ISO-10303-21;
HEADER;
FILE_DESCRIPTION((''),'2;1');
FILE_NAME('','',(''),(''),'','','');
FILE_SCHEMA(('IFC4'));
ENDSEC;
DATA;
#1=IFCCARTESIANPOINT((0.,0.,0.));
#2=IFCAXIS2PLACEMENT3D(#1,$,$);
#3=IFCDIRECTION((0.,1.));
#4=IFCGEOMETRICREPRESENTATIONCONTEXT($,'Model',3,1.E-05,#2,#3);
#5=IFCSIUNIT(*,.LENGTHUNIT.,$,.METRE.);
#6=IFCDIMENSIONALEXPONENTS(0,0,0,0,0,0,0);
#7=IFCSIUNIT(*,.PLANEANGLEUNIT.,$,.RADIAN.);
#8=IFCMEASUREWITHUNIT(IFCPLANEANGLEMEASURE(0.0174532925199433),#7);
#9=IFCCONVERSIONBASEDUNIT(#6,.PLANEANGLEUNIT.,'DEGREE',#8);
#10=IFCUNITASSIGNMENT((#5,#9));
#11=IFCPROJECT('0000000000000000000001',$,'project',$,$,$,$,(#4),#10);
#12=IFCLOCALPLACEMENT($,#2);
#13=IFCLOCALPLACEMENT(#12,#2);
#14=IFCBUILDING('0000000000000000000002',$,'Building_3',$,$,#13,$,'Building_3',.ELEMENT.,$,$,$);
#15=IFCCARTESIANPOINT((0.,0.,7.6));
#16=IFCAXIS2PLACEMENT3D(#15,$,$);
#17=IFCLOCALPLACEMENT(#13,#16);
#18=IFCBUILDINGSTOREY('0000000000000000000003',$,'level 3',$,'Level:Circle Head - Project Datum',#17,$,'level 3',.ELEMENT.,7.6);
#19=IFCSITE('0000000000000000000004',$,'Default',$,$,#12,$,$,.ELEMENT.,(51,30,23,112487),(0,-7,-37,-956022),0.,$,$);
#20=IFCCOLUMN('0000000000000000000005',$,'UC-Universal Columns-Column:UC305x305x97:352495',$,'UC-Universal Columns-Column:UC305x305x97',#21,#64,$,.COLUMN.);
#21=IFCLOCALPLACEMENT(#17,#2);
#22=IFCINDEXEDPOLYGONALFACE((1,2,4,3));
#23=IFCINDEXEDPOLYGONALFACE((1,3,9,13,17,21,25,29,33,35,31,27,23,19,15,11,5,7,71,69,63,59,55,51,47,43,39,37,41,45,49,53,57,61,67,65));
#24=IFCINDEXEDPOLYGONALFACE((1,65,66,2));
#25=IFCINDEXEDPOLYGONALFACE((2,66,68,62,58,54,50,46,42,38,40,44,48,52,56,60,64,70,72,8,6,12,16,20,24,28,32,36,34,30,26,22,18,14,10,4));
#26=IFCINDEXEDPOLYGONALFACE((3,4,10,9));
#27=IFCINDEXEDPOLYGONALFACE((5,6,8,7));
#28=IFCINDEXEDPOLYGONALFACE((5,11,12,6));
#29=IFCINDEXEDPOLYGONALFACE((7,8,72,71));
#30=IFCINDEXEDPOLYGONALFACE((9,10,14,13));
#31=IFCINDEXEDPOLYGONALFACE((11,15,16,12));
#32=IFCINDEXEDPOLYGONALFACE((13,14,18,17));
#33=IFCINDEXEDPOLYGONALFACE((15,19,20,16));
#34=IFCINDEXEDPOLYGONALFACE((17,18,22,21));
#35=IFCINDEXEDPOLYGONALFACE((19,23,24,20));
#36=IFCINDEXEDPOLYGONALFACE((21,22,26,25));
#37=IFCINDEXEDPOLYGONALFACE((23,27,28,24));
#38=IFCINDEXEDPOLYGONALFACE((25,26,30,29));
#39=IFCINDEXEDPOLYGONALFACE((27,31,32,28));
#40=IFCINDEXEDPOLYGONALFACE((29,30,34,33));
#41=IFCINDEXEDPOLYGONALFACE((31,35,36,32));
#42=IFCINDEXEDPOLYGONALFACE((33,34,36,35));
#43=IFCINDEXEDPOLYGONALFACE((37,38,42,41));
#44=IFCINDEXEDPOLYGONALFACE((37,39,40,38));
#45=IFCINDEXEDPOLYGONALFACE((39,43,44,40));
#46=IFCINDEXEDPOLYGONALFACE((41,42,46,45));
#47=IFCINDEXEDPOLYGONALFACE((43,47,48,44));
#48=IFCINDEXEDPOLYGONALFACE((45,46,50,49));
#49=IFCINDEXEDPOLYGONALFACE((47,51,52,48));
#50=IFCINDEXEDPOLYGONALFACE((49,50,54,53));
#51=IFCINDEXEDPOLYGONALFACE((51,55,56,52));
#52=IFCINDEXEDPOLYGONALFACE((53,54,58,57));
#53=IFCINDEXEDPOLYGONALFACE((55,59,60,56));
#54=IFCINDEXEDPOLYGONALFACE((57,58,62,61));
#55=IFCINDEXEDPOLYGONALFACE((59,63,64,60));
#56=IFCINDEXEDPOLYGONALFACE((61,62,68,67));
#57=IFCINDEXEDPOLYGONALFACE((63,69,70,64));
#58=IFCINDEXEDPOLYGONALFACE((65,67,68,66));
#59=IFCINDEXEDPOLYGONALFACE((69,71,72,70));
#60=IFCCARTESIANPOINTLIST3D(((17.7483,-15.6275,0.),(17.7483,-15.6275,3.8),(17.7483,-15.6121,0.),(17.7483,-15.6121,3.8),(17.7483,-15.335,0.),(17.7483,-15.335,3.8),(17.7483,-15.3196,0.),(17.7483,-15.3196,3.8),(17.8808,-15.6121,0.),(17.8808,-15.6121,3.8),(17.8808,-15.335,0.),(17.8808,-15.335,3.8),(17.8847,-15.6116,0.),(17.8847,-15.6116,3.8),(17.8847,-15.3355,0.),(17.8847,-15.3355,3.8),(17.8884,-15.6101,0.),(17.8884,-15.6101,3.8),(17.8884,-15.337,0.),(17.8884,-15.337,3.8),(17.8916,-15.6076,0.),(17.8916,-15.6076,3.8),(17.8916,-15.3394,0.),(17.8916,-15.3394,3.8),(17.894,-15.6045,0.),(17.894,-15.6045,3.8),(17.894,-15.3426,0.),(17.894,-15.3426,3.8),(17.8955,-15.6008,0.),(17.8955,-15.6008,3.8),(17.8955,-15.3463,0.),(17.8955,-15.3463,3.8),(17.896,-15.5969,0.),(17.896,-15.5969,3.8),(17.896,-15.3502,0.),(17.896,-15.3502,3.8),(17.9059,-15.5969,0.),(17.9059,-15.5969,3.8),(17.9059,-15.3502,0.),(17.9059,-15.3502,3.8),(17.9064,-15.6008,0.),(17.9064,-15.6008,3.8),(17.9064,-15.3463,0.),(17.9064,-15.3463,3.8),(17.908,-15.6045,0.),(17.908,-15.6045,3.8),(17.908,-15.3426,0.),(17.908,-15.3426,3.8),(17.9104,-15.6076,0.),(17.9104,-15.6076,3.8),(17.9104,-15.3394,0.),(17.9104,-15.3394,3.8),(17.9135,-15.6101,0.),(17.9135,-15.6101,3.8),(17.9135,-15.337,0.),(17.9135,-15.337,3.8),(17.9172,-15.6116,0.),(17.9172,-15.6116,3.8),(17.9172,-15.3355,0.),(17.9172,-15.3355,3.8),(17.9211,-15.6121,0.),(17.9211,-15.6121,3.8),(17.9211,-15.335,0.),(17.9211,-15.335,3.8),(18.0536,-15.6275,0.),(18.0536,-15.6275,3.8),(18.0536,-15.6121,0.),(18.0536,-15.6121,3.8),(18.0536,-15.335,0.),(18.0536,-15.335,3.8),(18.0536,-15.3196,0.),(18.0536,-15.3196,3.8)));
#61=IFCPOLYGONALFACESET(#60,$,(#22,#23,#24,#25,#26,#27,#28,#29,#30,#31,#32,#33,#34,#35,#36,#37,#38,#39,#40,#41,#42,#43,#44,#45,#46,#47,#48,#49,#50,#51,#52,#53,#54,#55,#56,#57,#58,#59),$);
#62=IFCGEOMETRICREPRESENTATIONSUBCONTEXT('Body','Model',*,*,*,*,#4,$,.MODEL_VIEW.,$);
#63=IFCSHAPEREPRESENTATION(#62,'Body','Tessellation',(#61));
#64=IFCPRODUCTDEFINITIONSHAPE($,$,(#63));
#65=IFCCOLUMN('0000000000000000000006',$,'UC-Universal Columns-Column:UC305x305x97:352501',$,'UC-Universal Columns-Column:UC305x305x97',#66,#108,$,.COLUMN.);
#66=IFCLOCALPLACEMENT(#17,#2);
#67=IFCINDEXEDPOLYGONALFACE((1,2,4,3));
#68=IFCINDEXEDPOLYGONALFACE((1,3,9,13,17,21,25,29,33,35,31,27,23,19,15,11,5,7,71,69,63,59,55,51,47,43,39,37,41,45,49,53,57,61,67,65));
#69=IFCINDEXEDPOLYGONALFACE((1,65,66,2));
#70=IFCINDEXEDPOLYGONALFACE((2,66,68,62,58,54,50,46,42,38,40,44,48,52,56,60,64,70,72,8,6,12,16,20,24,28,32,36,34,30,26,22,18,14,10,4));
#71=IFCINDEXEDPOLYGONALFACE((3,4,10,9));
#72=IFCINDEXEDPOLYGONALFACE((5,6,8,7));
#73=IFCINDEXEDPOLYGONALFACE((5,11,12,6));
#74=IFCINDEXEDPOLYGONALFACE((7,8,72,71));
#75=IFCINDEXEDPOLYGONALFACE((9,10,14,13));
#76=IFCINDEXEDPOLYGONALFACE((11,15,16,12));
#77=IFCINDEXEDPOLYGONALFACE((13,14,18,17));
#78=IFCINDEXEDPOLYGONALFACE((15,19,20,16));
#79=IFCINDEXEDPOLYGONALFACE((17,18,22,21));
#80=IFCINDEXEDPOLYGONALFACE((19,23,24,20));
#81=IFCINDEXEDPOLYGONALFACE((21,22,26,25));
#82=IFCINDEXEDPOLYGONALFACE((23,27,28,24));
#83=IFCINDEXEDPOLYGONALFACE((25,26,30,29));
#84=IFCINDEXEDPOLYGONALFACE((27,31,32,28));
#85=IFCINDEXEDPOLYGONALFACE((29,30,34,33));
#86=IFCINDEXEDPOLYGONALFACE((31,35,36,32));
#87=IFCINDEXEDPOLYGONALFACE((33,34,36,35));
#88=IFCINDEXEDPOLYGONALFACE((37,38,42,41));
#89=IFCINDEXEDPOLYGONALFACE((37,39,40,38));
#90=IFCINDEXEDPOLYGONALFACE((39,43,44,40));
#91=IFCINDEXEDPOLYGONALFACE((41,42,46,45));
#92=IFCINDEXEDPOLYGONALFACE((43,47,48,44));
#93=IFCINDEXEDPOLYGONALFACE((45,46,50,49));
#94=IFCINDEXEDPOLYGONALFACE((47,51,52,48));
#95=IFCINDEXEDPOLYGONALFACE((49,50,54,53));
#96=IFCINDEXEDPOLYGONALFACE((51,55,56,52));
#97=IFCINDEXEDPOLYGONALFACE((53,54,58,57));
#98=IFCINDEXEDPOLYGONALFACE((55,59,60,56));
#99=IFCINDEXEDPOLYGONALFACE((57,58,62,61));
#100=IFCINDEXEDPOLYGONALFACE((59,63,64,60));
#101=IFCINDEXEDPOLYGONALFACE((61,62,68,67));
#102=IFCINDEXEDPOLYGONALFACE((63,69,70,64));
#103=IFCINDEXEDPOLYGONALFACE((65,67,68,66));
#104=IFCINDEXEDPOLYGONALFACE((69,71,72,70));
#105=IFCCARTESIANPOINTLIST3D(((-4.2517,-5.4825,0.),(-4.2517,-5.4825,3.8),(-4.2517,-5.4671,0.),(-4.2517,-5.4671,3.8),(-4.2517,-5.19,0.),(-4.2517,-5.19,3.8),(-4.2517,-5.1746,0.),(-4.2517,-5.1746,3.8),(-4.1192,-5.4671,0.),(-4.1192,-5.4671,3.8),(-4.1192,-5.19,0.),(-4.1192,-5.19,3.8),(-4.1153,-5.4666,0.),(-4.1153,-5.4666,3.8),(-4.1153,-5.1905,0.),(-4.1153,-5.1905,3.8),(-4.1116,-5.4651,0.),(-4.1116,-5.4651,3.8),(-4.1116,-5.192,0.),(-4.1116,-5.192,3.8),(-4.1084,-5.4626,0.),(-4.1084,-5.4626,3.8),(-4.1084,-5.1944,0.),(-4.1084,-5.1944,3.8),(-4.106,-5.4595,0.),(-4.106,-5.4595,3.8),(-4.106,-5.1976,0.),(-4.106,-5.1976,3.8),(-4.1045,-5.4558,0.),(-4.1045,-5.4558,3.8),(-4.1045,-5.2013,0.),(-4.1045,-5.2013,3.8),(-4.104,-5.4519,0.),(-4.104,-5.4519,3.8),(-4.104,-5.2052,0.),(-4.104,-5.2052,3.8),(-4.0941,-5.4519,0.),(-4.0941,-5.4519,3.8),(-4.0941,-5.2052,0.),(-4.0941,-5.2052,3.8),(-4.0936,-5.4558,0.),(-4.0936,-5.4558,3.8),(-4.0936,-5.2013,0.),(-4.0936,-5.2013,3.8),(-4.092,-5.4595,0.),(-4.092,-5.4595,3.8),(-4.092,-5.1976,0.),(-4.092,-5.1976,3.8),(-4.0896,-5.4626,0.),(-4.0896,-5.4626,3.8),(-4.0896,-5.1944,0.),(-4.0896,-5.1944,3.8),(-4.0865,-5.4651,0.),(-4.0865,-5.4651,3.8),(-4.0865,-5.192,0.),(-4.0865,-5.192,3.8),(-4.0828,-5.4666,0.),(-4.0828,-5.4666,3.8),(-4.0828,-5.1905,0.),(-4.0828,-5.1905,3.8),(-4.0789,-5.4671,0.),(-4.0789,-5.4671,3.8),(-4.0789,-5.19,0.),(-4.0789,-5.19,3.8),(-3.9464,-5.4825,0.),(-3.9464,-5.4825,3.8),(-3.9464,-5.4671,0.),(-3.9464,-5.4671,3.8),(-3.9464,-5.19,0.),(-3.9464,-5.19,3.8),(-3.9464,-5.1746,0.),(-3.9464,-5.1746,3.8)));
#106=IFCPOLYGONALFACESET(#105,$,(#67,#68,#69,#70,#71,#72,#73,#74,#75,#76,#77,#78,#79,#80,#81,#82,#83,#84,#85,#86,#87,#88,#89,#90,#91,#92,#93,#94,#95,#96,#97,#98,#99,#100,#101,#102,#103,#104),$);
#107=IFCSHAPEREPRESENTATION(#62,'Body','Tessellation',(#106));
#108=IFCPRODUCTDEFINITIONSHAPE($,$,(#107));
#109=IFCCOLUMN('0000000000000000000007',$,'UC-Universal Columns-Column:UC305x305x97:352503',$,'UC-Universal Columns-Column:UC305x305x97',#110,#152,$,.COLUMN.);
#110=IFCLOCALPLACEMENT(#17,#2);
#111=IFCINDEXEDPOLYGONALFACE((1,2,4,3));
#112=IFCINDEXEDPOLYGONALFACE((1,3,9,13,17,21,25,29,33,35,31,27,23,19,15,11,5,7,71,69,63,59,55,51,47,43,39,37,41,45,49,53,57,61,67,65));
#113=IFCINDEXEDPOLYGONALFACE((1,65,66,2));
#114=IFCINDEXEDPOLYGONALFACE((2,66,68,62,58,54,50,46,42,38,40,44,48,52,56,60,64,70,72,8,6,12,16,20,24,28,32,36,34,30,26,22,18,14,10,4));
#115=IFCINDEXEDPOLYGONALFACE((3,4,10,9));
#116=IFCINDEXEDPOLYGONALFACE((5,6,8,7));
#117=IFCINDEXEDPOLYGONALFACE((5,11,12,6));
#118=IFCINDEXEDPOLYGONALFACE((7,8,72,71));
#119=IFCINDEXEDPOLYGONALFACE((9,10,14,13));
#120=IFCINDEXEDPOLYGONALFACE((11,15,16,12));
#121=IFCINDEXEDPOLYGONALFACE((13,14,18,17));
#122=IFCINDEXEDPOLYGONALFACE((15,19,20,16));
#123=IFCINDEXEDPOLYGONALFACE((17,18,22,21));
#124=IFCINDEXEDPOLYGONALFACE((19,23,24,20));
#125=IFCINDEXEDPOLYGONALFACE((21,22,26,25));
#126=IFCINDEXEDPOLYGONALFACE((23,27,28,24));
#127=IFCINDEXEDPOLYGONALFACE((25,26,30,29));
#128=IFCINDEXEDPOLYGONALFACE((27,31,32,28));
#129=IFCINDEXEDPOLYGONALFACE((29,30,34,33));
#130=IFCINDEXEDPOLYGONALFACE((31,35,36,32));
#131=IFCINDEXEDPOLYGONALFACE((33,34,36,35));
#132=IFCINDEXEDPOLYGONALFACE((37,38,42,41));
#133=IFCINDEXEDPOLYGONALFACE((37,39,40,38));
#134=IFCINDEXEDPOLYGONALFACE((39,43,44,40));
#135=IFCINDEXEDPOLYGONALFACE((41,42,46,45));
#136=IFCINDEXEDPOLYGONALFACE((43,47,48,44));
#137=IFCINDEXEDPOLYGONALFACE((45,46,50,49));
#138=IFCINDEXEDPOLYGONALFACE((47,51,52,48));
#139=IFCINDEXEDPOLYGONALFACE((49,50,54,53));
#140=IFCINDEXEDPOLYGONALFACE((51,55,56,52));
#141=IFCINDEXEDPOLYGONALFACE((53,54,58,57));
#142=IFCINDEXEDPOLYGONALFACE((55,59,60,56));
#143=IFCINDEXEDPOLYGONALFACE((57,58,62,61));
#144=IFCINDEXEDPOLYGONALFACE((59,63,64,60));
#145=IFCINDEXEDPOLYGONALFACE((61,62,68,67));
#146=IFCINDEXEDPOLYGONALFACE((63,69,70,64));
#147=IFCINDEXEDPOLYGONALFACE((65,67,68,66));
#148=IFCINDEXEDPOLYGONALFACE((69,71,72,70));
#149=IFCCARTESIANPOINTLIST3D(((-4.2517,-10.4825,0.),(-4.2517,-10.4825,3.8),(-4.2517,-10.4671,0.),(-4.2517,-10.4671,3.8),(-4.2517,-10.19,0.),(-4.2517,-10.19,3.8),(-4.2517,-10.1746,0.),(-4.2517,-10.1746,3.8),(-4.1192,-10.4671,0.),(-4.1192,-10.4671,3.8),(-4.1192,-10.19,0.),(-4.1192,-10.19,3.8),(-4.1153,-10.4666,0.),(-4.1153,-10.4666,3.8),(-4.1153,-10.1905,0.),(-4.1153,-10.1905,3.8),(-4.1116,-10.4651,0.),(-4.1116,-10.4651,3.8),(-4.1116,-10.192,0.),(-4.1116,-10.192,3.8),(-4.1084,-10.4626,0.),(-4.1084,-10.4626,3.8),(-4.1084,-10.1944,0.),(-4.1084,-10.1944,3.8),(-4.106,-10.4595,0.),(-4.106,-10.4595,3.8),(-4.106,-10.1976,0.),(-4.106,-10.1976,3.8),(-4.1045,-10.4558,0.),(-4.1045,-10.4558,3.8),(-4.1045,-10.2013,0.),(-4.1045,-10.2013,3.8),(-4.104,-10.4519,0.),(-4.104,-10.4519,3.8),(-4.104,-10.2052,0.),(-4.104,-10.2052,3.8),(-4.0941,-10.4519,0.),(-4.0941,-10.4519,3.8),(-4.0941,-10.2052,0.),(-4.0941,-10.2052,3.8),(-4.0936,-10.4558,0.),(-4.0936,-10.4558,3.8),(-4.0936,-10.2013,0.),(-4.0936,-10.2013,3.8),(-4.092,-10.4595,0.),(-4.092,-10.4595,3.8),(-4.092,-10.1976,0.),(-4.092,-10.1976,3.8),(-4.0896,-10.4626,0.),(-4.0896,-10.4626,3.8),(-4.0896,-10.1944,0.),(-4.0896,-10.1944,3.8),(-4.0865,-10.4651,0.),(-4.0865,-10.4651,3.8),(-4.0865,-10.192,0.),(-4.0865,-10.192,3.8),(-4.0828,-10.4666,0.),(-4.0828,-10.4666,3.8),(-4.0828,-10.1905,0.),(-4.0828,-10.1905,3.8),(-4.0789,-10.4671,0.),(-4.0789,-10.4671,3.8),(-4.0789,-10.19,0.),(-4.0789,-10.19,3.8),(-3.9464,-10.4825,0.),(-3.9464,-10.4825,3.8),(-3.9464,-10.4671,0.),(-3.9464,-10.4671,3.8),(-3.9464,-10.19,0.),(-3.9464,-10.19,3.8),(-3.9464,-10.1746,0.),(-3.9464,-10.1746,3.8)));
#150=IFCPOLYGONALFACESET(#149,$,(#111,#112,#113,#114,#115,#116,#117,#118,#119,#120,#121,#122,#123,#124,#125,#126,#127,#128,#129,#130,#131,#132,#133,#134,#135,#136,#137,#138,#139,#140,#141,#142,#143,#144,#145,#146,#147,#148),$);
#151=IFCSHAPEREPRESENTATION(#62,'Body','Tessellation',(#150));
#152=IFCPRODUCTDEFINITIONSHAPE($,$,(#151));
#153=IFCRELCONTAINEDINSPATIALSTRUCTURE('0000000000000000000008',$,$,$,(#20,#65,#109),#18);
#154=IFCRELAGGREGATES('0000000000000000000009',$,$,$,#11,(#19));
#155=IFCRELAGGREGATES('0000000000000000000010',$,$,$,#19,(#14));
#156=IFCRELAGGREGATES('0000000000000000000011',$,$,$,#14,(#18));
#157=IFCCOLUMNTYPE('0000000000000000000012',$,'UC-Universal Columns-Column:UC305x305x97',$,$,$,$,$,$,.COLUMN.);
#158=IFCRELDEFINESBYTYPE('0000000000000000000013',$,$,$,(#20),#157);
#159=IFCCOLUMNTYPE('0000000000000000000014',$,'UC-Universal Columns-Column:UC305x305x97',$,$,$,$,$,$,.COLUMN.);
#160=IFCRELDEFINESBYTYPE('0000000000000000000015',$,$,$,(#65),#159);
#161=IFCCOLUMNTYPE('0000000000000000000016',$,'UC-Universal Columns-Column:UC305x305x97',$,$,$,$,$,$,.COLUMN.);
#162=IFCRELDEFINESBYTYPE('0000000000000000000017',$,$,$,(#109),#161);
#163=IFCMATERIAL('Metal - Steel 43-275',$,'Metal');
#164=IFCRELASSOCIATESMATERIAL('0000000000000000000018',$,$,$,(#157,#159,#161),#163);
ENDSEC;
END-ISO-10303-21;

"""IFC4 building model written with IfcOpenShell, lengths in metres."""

from ifc_helpers import new_model, entity, si_unit, converted_unit, direction, frame, frame_2d, origin, origin_2d_with_axis, place, context, subcontext, project, spatial, i_section, extrude, source, transform, mapped, material, material_profile, profile_set, type_object, type_shapes, element, save


model = new_model("IFC4")

# Units and contexts
model_context = context("Model", 3, precision=1e-05, world=origin(), true_north=direction((0.0, 1.0)))
body_context = subcontext(model_context, "Body", "Model", "MODEL_VIEW")
ifc_project = project(units=[si_unit("LENGTHUNIT", "METRE"), converted_unit("PLANEANGLEUNIT", "DEGREE", entity("IfcPlaneAngleMeasure", 0.0174532925199433), si_unit("PLANEANGLEUNIT", "RADIAN"), dimensions=[0, 0, 0, 0, 0, 0, 0])], contexts=[model_context])

# Site, building, storey
site_placement = place(None, origin())
site = spatial("IfcSite", under=ifc_project, at=site_placement, Name="Default", CompositionType="ELEMENT", RefLatitude=(51, 30, 23, 112487), RefLongitude=(0, -7, -37, -956022), RefElevation=0.0)
building_placement = place(site_placement, origin())
building = spatial("IfcBuilding", under=site, at=building_placement, Name="Building_3", LongName="Building_3", CompositionType="ELEMENT")
storey_placement = place(building_placement, frame((0.0, 0.0, 7.6)))
storey = spatial("IfcBuildingStorey", under=building, at=storey_placement, Name="level 3", ObjectType="Level:Circle Head - Project Datum", LongName="level 3", CompositionType="ELEMENT", Elevation=7.6)

# Columns
ifc_material_1 = material(Name="Metal - Steel 43-275", Category="Metal")
ifc_material_profile_1 = material_profile(ifc_material_1, i_section(OverallWidth=0.3053, OverallDepth=0.3079, WebThickness=0.0099, FlangeThickness=0.0154, FilletRadius=0.0152, at=frame_2d((0.0, 0.0), x_axis=(1.0, 0.0))), Name="UC305x305x97")
ifc_profile_set_1 = profile_set([ifc_material_profile_1], Name="UC305x305x97")
column_type_1 = type_object("IfcColumnType", Name="UC-Universal Columns-Column:UC305x305x97", PredefinedType="COLUMN", material=ifc_profile_set_1)
shared_shape_1 = source(origin(), body_context, "Body", "SweptSolid", [
    extrude(i_section(OverallWidth=0.3053, OverallDepth=0.3079, WebThickness=0.0099, FlangeThickness=0.0154, FilletRadius=0.0152, at=frame_2d((0.0, 0.0), x_axis=(1.0, 0.0))), frame((17.901, -15.4735, 7.6), z_axis=(0.0, 0.0, 1.0), x_axis=(-1.0, 0.0, 0.0)), (0.0, 0.0, 1.0), 3.8),
])
type_shapes(column_type_1, [shared_shape_1])
column_1_placement = place(storey_placement, frame((0.0, 0.0, -7.6)))
element("IfcColumn", 1, at=column_1_placement, inside=storey, type_object=column_type_1, Name="UC-Universal Columns-Column:UC305x305x97:352495", ObjectType="UC-Universal Columns-Column:UC305x305x97", PredefinedType="COLUMN", context=body_context, shape_type="MappedRepresentation", body=[
    mapped(shared_shape_1, transform((0.0, 0.0, 0.0), scale=1.0)),
])
column_type_2 = type_object("IfcColumnType", Name="UC-Universal Columns-Column:UC305x305x97", PredefinedType="COLUMN", material=ifc_profile_set_1)
shared_shape_2 = source(origin(), body_context, "Body", "SweptSolid", [
    extrude(i_section(OverallWidth=0.3053, OverallDepth=0.3079, WebThickness=0.0099, FlangeThickness=0.0154, FilletRadius=0.0152, at=frame_2d((0.0, 0.0), x_axis=(1.0, 0.0))), frame((-4.099, -5.3285, 7.6), z_axis=(0.0, 0.0, 1.0), x_axis=(-1.0, 0.0, 0.0)), (0.0, 0.0, 1.0), 3.8),
])
type_shapes(column_type_2, [shared_shape_2])
column_2_placement = place(storey_placement, frame((0.0, 0.0, -7.6)))
element("IfcColumn", 2, at=column_2_placement, inside=storey, type_object=column_type_2, Name="UC-Universal Columns-Column:UC305x305x97:352501", ObjectType="UC-Universal Columns-Column:UC305x305x97", PredefinedType="COLUMN", context=body_context, shape_type="MappedRepresentation", body=[
    mapped(shared_shape_2, transform((0.0, 0.0, 0.0), scale=1.0)),
])
column_type_3 = type_object("IfcColumnType", Name="UC-Universal Columns-Column:UC305x305x97", PredefinedType="COLUMN", material=ifc_profile_set_1)
shared_shape_3 = source(origin(), body_context, "Body", "SweptSolid", [
    extrude(i_section(OverallWidth=0.3053, OverallDepth=0.3079, WebThickness=0.0099, FlangeThickness=0.0154, FilletRadius=0.0152, at=origin_2d_with_axis()), frame((-4.099, -10.3285, 7.6), z_axis=(0.0, 0.0, 1.0), x_axis=(-1.0, 0.0, 0.0)), (0.0, 0.0, 1.0), 3.8),
])
type_shapes(column_type_3, [shared_shape_3])
column_3_placement = place(storey_placement, frame((0.0, 0.0, -7.6)))
element("IfcColumn", 3, at=column_3_placement, inside=storey, type_object=column_type_3, Name="UC-Universal Columns-Column:UC305x305x97:352503", ObjectType="UC-Universal Columns-Column:UC305x305x97", PredefinedType="COLUMN", context=body_context, shape_type="MappedRepresentation", body=[
    mapped(shared_shape_3, transform((0.0, 0.0, 0.0), scale=1.0)),
])

save(model, "model.ifc")
